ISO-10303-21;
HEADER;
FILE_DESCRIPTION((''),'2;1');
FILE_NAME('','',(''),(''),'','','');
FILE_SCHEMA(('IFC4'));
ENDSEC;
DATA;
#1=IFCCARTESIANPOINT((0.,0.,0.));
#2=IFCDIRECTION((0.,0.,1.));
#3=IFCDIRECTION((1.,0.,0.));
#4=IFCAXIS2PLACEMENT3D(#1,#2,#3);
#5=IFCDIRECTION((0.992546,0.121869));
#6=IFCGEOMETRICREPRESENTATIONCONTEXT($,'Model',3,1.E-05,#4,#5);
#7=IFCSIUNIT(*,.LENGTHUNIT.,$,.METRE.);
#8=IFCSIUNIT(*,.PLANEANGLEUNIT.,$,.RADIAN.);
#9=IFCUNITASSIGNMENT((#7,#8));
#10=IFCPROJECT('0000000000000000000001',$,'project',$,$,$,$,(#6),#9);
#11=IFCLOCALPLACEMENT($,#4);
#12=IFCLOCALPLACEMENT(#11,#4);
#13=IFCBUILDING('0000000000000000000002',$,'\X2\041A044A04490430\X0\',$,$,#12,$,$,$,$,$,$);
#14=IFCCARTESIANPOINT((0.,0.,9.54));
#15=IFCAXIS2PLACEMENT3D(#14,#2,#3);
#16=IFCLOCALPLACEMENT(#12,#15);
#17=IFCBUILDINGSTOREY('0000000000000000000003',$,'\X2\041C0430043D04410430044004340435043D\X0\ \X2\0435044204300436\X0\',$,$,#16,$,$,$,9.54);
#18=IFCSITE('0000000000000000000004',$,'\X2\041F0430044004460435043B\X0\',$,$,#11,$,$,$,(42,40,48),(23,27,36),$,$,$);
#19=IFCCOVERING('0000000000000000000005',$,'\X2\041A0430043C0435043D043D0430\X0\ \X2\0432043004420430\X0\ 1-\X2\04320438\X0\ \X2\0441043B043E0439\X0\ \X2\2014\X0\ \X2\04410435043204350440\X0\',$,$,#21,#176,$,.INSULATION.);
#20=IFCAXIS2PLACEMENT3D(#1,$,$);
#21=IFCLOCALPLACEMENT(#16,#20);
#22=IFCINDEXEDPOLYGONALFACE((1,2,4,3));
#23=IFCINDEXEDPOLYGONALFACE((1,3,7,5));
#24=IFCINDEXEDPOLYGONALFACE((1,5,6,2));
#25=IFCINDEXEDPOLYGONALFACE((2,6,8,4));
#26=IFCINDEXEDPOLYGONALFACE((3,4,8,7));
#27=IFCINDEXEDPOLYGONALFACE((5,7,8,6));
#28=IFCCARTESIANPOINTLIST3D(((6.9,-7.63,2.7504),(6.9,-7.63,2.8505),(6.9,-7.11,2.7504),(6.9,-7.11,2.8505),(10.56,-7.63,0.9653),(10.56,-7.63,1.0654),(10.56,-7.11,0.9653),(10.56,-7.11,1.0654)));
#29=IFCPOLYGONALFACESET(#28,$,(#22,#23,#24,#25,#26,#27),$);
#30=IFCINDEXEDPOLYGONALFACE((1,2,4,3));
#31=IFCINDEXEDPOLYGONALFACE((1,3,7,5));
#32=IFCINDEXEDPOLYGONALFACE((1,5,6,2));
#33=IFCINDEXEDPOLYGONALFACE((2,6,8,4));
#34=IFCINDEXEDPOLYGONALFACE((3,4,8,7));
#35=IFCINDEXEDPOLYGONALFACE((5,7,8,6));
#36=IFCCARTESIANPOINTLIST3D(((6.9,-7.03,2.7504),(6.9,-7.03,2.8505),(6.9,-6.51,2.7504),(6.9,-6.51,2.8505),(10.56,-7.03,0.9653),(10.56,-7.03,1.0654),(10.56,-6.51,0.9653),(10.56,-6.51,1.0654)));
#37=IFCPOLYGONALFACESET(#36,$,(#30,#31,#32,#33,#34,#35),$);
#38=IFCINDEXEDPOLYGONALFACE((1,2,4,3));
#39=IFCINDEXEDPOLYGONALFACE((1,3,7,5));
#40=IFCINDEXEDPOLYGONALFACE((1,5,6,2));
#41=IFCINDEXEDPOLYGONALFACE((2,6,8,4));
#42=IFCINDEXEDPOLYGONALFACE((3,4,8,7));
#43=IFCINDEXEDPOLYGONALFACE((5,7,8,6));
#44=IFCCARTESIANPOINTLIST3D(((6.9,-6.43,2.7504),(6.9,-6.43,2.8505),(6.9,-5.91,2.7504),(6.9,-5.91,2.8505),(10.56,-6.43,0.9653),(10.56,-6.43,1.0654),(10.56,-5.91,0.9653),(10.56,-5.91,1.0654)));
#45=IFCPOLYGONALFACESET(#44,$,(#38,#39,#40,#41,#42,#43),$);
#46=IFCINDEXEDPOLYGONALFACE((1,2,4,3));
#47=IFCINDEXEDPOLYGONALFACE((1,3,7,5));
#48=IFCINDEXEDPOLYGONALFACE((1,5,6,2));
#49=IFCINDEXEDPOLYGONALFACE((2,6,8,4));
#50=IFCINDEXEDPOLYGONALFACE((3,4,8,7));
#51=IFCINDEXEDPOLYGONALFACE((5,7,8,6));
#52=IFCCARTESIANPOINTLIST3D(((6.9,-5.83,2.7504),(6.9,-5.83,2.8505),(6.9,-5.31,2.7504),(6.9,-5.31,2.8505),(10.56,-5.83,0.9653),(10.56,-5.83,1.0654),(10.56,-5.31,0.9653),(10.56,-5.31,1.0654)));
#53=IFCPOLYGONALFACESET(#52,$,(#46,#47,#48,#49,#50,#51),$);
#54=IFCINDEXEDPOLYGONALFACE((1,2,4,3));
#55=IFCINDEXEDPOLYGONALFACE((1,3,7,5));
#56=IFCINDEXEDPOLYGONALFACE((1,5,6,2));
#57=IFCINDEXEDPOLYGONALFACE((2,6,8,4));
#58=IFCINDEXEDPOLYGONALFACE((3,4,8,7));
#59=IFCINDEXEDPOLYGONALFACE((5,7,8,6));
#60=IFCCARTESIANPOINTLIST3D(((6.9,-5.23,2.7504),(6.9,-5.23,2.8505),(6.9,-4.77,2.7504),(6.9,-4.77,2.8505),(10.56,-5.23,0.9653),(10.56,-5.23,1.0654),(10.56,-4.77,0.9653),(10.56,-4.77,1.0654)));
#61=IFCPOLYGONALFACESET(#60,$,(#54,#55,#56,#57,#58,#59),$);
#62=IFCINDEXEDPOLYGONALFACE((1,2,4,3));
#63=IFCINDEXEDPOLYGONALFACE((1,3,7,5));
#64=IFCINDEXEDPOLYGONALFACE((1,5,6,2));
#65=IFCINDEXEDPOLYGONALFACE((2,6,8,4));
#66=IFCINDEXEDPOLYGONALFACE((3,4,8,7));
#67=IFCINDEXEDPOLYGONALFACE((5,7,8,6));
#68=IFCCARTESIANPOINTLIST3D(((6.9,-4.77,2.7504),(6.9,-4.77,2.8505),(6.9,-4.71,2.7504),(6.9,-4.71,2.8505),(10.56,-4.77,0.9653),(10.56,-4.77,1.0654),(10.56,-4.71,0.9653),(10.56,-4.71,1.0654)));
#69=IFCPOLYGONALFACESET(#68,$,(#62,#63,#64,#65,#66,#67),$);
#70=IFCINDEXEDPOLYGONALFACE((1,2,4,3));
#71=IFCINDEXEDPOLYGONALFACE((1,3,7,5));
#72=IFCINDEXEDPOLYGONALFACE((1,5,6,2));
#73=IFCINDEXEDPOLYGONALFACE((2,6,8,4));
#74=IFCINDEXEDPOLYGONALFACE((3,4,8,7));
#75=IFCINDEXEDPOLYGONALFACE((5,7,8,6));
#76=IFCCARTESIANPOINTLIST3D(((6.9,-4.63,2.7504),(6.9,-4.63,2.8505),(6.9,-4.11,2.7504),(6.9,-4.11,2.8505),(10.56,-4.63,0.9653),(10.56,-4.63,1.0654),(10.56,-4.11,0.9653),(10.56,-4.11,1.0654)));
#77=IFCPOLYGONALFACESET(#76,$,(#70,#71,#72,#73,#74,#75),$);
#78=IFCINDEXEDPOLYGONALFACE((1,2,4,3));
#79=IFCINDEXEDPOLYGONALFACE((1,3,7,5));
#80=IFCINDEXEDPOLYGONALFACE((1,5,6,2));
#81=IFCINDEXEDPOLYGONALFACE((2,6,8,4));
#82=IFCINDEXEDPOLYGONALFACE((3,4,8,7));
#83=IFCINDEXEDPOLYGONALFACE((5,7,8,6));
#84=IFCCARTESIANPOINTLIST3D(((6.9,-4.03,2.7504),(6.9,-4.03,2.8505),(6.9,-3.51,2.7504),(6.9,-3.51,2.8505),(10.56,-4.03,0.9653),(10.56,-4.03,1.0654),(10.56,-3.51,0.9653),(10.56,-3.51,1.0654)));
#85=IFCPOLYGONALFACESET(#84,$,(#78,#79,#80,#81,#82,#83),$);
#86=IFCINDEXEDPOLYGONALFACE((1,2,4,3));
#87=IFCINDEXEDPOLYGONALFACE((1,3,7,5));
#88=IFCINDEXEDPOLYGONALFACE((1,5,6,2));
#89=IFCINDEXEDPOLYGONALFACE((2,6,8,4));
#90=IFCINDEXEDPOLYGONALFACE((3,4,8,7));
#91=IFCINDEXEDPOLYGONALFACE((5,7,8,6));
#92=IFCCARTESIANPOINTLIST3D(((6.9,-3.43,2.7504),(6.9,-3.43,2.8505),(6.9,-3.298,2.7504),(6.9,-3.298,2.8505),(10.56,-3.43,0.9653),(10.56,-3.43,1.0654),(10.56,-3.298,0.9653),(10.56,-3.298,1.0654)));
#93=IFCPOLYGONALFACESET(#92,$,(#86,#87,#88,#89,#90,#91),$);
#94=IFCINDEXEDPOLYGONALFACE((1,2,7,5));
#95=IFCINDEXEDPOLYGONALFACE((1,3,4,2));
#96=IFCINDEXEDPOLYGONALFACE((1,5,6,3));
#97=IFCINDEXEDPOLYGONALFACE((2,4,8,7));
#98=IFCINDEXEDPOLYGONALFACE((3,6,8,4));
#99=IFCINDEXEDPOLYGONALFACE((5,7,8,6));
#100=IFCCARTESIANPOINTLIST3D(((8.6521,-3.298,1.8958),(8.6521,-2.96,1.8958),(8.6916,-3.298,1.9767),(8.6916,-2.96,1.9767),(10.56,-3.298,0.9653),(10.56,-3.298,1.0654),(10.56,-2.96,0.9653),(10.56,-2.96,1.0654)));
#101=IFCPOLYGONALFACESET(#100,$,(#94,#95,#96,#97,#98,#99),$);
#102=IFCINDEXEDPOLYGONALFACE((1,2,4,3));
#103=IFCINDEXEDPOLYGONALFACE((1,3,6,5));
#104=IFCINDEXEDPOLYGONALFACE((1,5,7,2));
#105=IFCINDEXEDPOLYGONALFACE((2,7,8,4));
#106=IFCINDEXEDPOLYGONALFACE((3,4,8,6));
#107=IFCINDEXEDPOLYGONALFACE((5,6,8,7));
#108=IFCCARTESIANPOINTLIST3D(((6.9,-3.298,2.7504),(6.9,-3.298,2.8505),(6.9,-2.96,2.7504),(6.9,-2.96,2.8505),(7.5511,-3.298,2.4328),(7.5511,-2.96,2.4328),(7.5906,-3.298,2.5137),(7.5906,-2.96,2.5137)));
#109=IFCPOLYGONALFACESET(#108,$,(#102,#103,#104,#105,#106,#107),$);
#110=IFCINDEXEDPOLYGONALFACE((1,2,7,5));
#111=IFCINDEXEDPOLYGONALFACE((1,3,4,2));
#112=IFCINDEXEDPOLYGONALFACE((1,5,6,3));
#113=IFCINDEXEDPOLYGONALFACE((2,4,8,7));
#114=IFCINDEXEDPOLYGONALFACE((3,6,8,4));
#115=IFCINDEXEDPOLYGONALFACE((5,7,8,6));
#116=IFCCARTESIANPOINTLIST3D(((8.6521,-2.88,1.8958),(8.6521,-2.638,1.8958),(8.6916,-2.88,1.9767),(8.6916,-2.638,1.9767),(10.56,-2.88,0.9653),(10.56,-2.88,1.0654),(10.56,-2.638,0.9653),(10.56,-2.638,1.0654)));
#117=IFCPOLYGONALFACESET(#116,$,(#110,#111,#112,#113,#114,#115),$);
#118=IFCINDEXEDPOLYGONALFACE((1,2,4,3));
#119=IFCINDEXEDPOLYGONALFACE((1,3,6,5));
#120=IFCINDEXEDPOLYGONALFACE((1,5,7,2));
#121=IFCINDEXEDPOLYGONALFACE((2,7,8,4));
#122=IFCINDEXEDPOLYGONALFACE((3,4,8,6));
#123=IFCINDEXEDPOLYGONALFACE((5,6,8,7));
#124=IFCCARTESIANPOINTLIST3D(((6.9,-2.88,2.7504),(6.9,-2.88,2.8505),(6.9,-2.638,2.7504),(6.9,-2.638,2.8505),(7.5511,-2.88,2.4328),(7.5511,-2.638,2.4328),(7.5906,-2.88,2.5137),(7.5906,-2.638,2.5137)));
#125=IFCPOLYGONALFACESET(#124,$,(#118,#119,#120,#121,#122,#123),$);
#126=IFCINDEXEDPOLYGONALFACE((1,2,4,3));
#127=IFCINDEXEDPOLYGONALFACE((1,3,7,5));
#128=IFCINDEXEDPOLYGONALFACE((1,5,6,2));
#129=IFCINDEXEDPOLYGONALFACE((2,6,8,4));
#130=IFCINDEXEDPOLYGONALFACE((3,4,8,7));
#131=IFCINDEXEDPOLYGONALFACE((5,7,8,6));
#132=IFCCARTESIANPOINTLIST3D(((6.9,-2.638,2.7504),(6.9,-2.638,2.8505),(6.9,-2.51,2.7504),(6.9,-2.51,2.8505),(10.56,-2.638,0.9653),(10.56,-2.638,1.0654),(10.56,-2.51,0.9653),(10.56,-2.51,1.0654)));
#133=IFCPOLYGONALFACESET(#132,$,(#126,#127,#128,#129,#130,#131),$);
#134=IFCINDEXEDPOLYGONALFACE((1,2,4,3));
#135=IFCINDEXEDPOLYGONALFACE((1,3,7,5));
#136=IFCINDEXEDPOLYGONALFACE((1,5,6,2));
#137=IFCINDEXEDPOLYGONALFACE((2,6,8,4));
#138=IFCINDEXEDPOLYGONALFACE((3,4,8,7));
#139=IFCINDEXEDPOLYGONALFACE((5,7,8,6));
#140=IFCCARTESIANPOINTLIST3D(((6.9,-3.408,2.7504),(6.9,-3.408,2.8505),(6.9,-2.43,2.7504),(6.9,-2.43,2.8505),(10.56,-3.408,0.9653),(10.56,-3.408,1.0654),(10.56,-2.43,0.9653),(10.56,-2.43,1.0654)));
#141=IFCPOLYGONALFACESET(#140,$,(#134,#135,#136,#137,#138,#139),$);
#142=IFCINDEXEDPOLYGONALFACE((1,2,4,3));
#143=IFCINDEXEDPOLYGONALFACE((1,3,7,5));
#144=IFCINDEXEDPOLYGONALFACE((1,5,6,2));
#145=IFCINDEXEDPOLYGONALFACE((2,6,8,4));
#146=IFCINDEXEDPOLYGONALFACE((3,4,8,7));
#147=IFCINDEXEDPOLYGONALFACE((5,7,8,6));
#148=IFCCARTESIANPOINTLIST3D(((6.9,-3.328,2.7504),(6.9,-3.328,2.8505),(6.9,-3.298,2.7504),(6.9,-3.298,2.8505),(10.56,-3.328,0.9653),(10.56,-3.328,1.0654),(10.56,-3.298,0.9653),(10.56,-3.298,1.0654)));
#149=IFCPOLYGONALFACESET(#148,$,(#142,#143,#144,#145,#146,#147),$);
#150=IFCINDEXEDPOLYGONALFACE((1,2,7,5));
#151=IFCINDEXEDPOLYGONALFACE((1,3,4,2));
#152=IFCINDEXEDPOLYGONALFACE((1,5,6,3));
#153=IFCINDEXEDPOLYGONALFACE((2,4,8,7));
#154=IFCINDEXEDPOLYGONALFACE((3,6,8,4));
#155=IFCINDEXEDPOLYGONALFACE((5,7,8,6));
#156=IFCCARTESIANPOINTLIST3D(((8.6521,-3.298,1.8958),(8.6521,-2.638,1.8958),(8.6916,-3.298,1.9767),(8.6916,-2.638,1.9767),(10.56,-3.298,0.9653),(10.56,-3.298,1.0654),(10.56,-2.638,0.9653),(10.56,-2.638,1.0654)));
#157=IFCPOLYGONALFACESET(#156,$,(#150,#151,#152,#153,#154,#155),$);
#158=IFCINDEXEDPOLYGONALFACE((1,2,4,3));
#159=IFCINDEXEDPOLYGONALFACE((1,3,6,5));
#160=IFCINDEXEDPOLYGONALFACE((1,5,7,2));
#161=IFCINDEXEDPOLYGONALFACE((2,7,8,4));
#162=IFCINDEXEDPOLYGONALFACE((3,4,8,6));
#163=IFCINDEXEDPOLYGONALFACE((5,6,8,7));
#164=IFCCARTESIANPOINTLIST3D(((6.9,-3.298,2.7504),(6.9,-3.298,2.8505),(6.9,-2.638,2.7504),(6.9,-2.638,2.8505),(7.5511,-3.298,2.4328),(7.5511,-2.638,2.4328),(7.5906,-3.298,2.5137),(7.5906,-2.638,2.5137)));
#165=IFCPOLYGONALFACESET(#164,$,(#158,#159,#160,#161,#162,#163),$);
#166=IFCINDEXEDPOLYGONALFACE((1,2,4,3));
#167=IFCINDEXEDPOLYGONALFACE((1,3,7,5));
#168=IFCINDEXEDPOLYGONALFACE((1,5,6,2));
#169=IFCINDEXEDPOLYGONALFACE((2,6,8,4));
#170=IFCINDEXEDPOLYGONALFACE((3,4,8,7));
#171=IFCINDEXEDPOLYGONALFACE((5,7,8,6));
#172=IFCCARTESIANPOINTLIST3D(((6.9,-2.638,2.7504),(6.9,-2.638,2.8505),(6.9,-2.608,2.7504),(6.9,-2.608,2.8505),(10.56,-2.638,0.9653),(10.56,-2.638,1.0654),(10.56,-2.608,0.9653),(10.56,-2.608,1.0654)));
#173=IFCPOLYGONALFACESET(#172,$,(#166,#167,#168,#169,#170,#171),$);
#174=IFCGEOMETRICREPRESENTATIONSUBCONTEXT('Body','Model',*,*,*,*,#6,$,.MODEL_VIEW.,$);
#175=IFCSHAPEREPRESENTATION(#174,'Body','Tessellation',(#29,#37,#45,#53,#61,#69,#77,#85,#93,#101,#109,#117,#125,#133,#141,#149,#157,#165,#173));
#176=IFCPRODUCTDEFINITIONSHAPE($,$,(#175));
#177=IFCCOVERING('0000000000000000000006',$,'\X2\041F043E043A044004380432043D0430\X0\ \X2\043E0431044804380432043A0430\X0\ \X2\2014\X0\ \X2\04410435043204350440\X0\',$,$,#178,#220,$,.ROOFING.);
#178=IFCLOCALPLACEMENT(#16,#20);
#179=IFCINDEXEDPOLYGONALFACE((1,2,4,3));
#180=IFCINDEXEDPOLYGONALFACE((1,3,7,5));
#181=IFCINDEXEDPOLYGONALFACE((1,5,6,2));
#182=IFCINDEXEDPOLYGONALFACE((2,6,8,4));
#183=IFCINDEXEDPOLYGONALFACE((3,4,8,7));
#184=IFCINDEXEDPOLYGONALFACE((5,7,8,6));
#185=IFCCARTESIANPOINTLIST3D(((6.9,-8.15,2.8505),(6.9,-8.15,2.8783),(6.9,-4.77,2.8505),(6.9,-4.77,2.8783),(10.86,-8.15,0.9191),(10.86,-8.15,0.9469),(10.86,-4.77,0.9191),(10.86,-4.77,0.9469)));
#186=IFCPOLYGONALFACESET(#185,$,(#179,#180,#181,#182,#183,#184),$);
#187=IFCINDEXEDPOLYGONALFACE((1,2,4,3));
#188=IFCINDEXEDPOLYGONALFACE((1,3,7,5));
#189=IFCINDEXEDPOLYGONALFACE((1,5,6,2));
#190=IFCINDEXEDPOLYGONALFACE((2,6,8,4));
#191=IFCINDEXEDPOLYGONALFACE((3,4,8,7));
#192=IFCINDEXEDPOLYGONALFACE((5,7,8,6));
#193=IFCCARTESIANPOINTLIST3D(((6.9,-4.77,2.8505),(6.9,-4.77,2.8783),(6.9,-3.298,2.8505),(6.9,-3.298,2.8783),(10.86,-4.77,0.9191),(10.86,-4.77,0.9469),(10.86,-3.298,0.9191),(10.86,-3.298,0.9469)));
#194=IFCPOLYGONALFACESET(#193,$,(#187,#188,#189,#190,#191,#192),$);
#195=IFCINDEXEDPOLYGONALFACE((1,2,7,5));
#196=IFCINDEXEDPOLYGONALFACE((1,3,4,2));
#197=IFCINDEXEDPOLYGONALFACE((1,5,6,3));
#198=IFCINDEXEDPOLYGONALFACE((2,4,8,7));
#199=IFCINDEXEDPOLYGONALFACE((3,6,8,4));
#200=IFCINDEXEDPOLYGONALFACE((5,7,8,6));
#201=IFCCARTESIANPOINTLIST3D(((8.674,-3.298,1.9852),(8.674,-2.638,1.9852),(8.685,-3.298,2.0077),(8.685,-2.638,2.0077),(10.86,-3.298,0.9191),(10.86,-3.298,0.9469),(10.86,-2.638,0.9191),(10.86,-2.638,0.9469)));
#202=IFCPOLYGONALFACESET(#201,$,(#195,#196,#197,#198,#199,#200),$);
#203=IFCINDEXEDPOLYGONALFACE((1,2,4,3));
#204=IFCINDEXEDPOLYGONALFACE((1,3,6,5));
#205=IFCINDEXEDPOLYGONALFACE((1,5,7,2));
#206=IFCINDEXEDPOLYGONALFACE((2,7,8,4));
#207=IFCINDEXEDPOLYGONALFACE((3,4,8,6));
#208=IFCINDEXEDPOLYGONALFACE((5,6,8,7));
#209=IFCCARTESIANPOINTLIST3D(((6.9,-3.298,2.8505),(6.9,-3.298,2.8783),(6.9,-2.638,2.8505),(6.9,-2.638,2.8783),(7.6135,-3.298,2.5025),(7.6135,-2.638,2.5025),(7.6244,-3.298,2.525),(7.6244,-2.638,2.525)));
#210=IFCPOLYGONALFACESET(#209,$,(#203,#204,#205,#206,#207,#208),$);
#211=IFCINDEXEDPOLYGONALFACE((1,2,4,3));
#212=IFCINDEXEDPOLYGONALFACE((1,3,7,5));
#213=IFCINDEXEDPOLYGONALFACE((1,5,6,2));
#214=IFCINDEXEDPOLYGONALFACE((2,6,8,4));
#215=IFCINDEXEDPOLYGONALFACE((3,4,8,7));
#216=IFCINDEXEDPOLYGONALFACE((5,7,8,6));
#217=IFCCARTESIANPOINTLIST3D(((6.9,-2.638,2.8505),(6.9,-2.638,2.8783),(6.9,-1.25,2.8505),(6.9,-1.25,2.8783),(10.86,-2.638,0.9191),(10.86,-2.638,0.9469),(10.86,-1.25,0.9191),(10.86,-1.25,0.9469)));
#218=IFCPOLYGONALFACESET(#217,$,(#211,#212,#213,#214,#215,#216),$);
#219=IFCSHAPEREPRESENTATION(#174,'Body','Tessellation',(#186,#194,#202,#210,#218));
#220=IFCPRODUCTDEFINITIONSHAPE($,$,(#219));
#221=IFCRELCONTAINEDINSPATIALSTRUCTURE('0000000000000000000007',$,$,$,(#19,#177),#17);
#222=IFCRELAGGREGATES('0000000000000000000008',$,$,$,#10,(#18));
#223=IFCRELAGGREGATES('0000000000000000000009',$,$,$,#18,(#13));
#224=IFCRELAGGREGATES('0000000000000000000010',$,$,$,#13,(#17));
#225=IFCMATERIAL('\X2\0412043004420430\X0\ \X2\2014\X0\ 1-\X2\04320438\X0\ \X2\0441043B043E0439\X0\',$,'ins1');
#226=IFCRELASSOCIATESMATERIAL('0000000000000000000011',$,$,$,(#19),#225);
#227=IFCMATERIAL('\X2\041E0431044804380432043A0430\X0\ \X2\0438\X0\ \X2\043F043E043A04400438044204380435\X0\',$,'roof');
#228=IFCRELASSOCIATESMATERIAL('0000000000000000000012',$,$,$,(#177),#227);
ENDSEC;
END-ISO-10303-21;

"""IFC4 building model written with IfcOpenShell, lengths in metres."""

from ifc_helpers import new_model, si_unit, direction, frame, origin_with_axes, place, context, subcontext, project, spatial, polyline, outline, extrude, material, element, save


model = new_model("IFC4")

# Units and contexts
model_context = context("Model", 3, precision=1e-05, world=origin_with_axes(), true_north=direction((0.992546, 0.121869)))
body_context = subcontext(model_context, "Body", "Model", "MODEL_VIEW")
ifc_project = project(units=[si_unit("LENGTHUNIT", "METRE"), si_unit("PLANEANGLEUNIT", "RADIAN")], contexts=[model_context])

# Site, building, storey
site_placement = place(None, origin_with_axes())
site = spatial("IfcSite", under=ifc_project, at=site_placement, Name="Парцел", RefLatitude=(42, 40, 48), RefLongitude=(23, 27, 36))
building_placement = place(site_placement, origin_with_axes())
building = spatial("IfcBuilding", under=site, at=building_placement, Name="Къща")
storey_placement = place(building_placement, frame((0.0, 0.0, 9.54), z_axis=(0.0, 0.0, 1.0), x_axis=(1.0, 0.0, 0.0)))
storey = spatial("IfcBuildingStorey", under=building, at=storey_placement, Name="Мансарден етаж", Elevation=9.54)

# Coverings
ifc_material_1 = material(Name="Вата — 1-ви слой", Category="ins1")
covering_1_placement = place(storey_placement, origin_with_axes())
element("IfcCovering", 1, at=covering_1_placement, inside=storey, material=ifc_material_1, Name="Каменна вата 1-ви слой — север", PredefinedType="INSULATION", context=body_context, shape_type="SweptSolid", body=[
    extrude(outline(polyline([(10.56, -0.9653), (6.9, -2.7504), (6.9, -2.8505), (10.56, -1.0654), (10.56, -0.9653)])), frame((0.0, -7.63, 0.0), z_axis=(0.0, 1.0, 0.0), x_axis=(1.0, 0.0, 0.0)), (0.0, 0.0, 1.0), 0.52),
    extrude(outline(polyline([(10.56, -0.9653), (6.9, -2.7504), (6.9, -2.8505), (10.56, -1.0654), (10.56, -0.9653)])), frame((0.0, -7.03, 0.0), z_axis=(0.0, 1.0, 0.0), x_axis=(1.0, 0.0, 0.0)), (0.0, 0.0, 1.0), 0.52),
    extrude(outline(polyline([(10.56, -0.9653), (6.9, -2.7504), (6.9, -2.8505), (10.56, -1.0654), (10.56, -0.9653)])), frame((0.0, -6.43, 0.0), z_axis=(0.0, 1.0, 0.0), x_axis=(1.0, 0.0, 0.0)), (0.0, 0.0, 1.0), 0.52),
    extrude(outline(polyline([(10.56, -0.9653), (6.9, -2.7504), (6.9, -2.8505), (10.56, -1.0654), (10.56, -0.9653)])), frame((0.0, -5.83, 0.0), z_axis=(0.0, 1.0, 0.0), x_axis=(1.0, 0.0, 0.0)), (0.0, 0.0, 1.0), 0.52),
    extrude(outline(polyline([(10.56, -0.9653), (6.9, -2.7504), (6.9, -2.8505), (10.56, -1.0654), (10.56, -0.9653)])), frame((0.0, -5.23, 0.0), z_axis=(0.0, 1.0, 0.0), x_axis=(1.0, 0.0, 0.0)), (0.0, 0.0, 1.0), 0.46),
    extrude(outline(polyline([(10.56, -0.9653), (6.9, -2.7504), (6.9, -2.8505), (10.56, -1.0654), (10.56, -0.9653)])), frame((0.0, -4.77, 0.0), z_axis=(0.0, 1.0, 0.0), x_axis=(1.0, 0.0, 0.0)), (0.0, 0.0, 1.0), 0.06),
    extrude(outline(polyline([(10.56, -0.9653), (6.9, -2.7504), (6.9, -2.8505), (10.56, -1.0654), (10.56, -0.9653)])), frame((0.0, -4.63, 0.0), z_axis=(0.0, 1.0, 0.0), x_axis=(1.0, 0.0, 0.0)), (0.0, 0.0, 1.0), 0.52),
    extrude(outline(polyline([(10.56, -0.9653), (6.9, -2.7504), (6.9, -2.8505), (10.56, -1.0654), (10.56, -0.9653)])), frame((0.0, -4.03, 0.0), z_axis=(0.0, 1.0, 0.0), x_axis=(1.0, 0.0, 0.0)), (0.0, 0.0, 1.0), 0.52),
    extrude(outline(polyline([(10.56, -0.9653), (6.9, -2.7504), (6.9, -2.8505), (10.56, -1.0654), (10.56, -0.9653)])), frame((0.0, -3.43, 0.0), z_axis=(0.0, 1.0, 0.0), x_axis=(1.0, 0.0, 0.0)), (0.0, 0.0, 1.0), 0.132),
    extrude(outline(polyline([(10.56, -0.9653), (8.6521, -1.8958), (8.6916, -1.9767), (10.56, -1.0654), (10.56, -0.9653)])), frame((0.0, -3.298, 0.0), z_axis=(0.0, 1.0, 0.0), x_axis=(1.0, 0.0, 0.0)), (0.0, 0.0, 1.0), 0.338),
    extrude(outline(polyline([(7.5511, -2.4328), (6.9, -2.7504), (6.9, -2.8505), (7.5906, -2.5137), (7.5511, -2.4328)])), frame((0.0, -3.298, 0.0), z_axis=(0.0, 1.0, 0.0), x_axis=(1.0, 0.0, 0.0)), (0.0, 0.0, 1.0), 0.338),
    extrude(outline(polyline([(10.56, -0.9653), (8.6521, -1.8958), (8.6916, -1.9767), (10.56, -1.0654), (10.56, -0.9653)])), frame((0.0, -2.88, 0.0), z_axis=(0.0, 1.0, 0.0), x_axis=(1.0, 0.0, 0.0)), (0.0, 0.0, 1.0), 0.242),
    extrude(outline(polyline([(7.5511, -2.4328), (6.9, -2.7504), (6.9, -2.8505), (7.5906, -2.5137), (7.5511, -2.4328)])), frame((0.0, -2.88, 0.0), z_axis=(0.0, 1.0, 0.0), x_axis=(1.0, 0.0, 0.0)), (0.0, 0.0, 1.0), 0.242),
    extrude(outline(polyline([(10.56, -0.9653), (6.9, -2.7504), (6.9, -2.8505), (10.56, -1.0654), (10.56, -0.9653)])), frame((0.0, -2.638, 0.0), z_axis=(0.0, 1.0, 0.0), x_axis=(1.0, 0.0, 0.0)), (0.0, 0.0, 1.0), 0.128),
    extrude(outline(polyline([(10.56, -0.9653), (6.9, -2.7504), (6.9, -2.8505), (10.56, -1.0654), (10.56, -0.9653)])), frame((0.0, -3.408, 0.0), z_axis=(0.0, 1.0, 0.0), x_axis=(1.0, 0.0, 0.0)), (0.0, 0.0, 1.0), 0.978),
    extrude(outline(polyline([(10.56, -0.9653), (6.9, -2.7504), (6.9, -2.8505), (10.56, -1.0654), (10.56, -0.9653)])), frame((0.0, -3.328, 0.0), z_axis=(0.0, 1.0, 0.0), x_axis=(1.0, 0.0, 0.0)), (0.0, 0.0, 1.0), 0.03),
    extrude(outline(polyline([(10.56, -0.9653), (8.6521, -1.8958), (8.6916, -1.9767), (10.56, -1.0654), (10.56, -0.9653)])), frame((0.0, -3.298, 0.0), z_axis=(0.0, 1.0, 0.0), x_axis=(1.0, 0.0, 0.0)), (0.0, 0.0, 1.0), 0.66),
    extrude(outline(polyline([(7.5511, -2.4328), (6.9, -2.7504), (6.9, -2.8505), (7.5906, -2.5137), (7.5511, -2.4328)])), frame((0.0, -3.298, 0.0), z_axis=(0.0, 1.0, 0.0), x_axis=(1.0, 0.0, 0.0)), (0.0, 0.0, 1.0), 0.66),
    extrude(outline(polyline([(10.56, -0.9653), (6.9, -2.7504), (6.9, -2.8505), (10.56, -1.0654), (10.56, -0.9653)])), frame((0.0, -2.638, 0.0), z_axis=(0.0, 1.0, 0.0), x_axis=(1.0, 0.0, 0.0)), (0.0, 0.0, 1.0), 0.03),
])
ifc_material_2 = material(Name="Обшивка и покритие", Category="roof")
covering_2_placement = place(storey_placement, origin_with_axes())
element("IfcCovering", 2, at=covering_2_placement, inside=storey, material=ifc_material_2, Name="Покривна обшивка — север", PredefinedType="ROOFING", context=body_context, shape_type="SweptSolid", body=[
    extrude(outline(polyline([(10.86, -0.9191), (6.9, -2.8505), (6.9, -2.8783), (10.86, -0.9469), (10.86, -0.9191)])), frame((0.0, -8.15, 0.0), z_axis=(0.0, 1.0, 0.0), x_axis=(1.0, 0.0, 0.0)), (0.0, 0.0, 1.0), 3.38),
    extrude(outline(polyline([(10.86, -0.9191), (6.9, -2.8505), (6.9, -2.8783), (10.86, -0.9469), (10.86, -0.9191)])), frame((0.0, -4.77, 0.0), z_axis=(0.0, 1.0, 0.0), x_axis=(1.0, 0.0, 0.0)), (0.0, 0.0, 1.0), 1.472),
    extrude(outline(polyline([(10.86, -0.9191), (8.674, -1.9852), (8.685, -2.0077), (10.86, -0.9469), (10.86, -0.9191)])), frame((0.0, -3.298, 0.0), z_axis=(0.0, 1.0, 0.0), x_axis=(1.0, 0.0, 0.0)), (0.0, 0.0, 1.0), 0.66),
    extrude(outline(polyline([(7.6135, -2.5025), (6.9, -2.8505), (6.9, -2.8783), (7.6244, -2.525), (7.6135, -2.5025)])), frame((0.0, -3.298, 0.0), z_axis=(0.0, 1.0, 0.0), x_axis=(1.0, 0.0, 0.0)), (0.0, 0.0, 1.0), 0.66),
    extrude(outline(polyline([(10.86, -0.9191), (6.9, -2.8505), (6.9, -2.8783), (10.86, -0.9469), (10.86, -0.9191)])), frame((0.0, -2.638, 0.0), z_axis=(0.0, 1.0, 0.0), x_axis=(1.0, 0.0, 0.0)), (0.0, 0.0, 1.0), 1.388),
])

save(model, "model.ifc")
